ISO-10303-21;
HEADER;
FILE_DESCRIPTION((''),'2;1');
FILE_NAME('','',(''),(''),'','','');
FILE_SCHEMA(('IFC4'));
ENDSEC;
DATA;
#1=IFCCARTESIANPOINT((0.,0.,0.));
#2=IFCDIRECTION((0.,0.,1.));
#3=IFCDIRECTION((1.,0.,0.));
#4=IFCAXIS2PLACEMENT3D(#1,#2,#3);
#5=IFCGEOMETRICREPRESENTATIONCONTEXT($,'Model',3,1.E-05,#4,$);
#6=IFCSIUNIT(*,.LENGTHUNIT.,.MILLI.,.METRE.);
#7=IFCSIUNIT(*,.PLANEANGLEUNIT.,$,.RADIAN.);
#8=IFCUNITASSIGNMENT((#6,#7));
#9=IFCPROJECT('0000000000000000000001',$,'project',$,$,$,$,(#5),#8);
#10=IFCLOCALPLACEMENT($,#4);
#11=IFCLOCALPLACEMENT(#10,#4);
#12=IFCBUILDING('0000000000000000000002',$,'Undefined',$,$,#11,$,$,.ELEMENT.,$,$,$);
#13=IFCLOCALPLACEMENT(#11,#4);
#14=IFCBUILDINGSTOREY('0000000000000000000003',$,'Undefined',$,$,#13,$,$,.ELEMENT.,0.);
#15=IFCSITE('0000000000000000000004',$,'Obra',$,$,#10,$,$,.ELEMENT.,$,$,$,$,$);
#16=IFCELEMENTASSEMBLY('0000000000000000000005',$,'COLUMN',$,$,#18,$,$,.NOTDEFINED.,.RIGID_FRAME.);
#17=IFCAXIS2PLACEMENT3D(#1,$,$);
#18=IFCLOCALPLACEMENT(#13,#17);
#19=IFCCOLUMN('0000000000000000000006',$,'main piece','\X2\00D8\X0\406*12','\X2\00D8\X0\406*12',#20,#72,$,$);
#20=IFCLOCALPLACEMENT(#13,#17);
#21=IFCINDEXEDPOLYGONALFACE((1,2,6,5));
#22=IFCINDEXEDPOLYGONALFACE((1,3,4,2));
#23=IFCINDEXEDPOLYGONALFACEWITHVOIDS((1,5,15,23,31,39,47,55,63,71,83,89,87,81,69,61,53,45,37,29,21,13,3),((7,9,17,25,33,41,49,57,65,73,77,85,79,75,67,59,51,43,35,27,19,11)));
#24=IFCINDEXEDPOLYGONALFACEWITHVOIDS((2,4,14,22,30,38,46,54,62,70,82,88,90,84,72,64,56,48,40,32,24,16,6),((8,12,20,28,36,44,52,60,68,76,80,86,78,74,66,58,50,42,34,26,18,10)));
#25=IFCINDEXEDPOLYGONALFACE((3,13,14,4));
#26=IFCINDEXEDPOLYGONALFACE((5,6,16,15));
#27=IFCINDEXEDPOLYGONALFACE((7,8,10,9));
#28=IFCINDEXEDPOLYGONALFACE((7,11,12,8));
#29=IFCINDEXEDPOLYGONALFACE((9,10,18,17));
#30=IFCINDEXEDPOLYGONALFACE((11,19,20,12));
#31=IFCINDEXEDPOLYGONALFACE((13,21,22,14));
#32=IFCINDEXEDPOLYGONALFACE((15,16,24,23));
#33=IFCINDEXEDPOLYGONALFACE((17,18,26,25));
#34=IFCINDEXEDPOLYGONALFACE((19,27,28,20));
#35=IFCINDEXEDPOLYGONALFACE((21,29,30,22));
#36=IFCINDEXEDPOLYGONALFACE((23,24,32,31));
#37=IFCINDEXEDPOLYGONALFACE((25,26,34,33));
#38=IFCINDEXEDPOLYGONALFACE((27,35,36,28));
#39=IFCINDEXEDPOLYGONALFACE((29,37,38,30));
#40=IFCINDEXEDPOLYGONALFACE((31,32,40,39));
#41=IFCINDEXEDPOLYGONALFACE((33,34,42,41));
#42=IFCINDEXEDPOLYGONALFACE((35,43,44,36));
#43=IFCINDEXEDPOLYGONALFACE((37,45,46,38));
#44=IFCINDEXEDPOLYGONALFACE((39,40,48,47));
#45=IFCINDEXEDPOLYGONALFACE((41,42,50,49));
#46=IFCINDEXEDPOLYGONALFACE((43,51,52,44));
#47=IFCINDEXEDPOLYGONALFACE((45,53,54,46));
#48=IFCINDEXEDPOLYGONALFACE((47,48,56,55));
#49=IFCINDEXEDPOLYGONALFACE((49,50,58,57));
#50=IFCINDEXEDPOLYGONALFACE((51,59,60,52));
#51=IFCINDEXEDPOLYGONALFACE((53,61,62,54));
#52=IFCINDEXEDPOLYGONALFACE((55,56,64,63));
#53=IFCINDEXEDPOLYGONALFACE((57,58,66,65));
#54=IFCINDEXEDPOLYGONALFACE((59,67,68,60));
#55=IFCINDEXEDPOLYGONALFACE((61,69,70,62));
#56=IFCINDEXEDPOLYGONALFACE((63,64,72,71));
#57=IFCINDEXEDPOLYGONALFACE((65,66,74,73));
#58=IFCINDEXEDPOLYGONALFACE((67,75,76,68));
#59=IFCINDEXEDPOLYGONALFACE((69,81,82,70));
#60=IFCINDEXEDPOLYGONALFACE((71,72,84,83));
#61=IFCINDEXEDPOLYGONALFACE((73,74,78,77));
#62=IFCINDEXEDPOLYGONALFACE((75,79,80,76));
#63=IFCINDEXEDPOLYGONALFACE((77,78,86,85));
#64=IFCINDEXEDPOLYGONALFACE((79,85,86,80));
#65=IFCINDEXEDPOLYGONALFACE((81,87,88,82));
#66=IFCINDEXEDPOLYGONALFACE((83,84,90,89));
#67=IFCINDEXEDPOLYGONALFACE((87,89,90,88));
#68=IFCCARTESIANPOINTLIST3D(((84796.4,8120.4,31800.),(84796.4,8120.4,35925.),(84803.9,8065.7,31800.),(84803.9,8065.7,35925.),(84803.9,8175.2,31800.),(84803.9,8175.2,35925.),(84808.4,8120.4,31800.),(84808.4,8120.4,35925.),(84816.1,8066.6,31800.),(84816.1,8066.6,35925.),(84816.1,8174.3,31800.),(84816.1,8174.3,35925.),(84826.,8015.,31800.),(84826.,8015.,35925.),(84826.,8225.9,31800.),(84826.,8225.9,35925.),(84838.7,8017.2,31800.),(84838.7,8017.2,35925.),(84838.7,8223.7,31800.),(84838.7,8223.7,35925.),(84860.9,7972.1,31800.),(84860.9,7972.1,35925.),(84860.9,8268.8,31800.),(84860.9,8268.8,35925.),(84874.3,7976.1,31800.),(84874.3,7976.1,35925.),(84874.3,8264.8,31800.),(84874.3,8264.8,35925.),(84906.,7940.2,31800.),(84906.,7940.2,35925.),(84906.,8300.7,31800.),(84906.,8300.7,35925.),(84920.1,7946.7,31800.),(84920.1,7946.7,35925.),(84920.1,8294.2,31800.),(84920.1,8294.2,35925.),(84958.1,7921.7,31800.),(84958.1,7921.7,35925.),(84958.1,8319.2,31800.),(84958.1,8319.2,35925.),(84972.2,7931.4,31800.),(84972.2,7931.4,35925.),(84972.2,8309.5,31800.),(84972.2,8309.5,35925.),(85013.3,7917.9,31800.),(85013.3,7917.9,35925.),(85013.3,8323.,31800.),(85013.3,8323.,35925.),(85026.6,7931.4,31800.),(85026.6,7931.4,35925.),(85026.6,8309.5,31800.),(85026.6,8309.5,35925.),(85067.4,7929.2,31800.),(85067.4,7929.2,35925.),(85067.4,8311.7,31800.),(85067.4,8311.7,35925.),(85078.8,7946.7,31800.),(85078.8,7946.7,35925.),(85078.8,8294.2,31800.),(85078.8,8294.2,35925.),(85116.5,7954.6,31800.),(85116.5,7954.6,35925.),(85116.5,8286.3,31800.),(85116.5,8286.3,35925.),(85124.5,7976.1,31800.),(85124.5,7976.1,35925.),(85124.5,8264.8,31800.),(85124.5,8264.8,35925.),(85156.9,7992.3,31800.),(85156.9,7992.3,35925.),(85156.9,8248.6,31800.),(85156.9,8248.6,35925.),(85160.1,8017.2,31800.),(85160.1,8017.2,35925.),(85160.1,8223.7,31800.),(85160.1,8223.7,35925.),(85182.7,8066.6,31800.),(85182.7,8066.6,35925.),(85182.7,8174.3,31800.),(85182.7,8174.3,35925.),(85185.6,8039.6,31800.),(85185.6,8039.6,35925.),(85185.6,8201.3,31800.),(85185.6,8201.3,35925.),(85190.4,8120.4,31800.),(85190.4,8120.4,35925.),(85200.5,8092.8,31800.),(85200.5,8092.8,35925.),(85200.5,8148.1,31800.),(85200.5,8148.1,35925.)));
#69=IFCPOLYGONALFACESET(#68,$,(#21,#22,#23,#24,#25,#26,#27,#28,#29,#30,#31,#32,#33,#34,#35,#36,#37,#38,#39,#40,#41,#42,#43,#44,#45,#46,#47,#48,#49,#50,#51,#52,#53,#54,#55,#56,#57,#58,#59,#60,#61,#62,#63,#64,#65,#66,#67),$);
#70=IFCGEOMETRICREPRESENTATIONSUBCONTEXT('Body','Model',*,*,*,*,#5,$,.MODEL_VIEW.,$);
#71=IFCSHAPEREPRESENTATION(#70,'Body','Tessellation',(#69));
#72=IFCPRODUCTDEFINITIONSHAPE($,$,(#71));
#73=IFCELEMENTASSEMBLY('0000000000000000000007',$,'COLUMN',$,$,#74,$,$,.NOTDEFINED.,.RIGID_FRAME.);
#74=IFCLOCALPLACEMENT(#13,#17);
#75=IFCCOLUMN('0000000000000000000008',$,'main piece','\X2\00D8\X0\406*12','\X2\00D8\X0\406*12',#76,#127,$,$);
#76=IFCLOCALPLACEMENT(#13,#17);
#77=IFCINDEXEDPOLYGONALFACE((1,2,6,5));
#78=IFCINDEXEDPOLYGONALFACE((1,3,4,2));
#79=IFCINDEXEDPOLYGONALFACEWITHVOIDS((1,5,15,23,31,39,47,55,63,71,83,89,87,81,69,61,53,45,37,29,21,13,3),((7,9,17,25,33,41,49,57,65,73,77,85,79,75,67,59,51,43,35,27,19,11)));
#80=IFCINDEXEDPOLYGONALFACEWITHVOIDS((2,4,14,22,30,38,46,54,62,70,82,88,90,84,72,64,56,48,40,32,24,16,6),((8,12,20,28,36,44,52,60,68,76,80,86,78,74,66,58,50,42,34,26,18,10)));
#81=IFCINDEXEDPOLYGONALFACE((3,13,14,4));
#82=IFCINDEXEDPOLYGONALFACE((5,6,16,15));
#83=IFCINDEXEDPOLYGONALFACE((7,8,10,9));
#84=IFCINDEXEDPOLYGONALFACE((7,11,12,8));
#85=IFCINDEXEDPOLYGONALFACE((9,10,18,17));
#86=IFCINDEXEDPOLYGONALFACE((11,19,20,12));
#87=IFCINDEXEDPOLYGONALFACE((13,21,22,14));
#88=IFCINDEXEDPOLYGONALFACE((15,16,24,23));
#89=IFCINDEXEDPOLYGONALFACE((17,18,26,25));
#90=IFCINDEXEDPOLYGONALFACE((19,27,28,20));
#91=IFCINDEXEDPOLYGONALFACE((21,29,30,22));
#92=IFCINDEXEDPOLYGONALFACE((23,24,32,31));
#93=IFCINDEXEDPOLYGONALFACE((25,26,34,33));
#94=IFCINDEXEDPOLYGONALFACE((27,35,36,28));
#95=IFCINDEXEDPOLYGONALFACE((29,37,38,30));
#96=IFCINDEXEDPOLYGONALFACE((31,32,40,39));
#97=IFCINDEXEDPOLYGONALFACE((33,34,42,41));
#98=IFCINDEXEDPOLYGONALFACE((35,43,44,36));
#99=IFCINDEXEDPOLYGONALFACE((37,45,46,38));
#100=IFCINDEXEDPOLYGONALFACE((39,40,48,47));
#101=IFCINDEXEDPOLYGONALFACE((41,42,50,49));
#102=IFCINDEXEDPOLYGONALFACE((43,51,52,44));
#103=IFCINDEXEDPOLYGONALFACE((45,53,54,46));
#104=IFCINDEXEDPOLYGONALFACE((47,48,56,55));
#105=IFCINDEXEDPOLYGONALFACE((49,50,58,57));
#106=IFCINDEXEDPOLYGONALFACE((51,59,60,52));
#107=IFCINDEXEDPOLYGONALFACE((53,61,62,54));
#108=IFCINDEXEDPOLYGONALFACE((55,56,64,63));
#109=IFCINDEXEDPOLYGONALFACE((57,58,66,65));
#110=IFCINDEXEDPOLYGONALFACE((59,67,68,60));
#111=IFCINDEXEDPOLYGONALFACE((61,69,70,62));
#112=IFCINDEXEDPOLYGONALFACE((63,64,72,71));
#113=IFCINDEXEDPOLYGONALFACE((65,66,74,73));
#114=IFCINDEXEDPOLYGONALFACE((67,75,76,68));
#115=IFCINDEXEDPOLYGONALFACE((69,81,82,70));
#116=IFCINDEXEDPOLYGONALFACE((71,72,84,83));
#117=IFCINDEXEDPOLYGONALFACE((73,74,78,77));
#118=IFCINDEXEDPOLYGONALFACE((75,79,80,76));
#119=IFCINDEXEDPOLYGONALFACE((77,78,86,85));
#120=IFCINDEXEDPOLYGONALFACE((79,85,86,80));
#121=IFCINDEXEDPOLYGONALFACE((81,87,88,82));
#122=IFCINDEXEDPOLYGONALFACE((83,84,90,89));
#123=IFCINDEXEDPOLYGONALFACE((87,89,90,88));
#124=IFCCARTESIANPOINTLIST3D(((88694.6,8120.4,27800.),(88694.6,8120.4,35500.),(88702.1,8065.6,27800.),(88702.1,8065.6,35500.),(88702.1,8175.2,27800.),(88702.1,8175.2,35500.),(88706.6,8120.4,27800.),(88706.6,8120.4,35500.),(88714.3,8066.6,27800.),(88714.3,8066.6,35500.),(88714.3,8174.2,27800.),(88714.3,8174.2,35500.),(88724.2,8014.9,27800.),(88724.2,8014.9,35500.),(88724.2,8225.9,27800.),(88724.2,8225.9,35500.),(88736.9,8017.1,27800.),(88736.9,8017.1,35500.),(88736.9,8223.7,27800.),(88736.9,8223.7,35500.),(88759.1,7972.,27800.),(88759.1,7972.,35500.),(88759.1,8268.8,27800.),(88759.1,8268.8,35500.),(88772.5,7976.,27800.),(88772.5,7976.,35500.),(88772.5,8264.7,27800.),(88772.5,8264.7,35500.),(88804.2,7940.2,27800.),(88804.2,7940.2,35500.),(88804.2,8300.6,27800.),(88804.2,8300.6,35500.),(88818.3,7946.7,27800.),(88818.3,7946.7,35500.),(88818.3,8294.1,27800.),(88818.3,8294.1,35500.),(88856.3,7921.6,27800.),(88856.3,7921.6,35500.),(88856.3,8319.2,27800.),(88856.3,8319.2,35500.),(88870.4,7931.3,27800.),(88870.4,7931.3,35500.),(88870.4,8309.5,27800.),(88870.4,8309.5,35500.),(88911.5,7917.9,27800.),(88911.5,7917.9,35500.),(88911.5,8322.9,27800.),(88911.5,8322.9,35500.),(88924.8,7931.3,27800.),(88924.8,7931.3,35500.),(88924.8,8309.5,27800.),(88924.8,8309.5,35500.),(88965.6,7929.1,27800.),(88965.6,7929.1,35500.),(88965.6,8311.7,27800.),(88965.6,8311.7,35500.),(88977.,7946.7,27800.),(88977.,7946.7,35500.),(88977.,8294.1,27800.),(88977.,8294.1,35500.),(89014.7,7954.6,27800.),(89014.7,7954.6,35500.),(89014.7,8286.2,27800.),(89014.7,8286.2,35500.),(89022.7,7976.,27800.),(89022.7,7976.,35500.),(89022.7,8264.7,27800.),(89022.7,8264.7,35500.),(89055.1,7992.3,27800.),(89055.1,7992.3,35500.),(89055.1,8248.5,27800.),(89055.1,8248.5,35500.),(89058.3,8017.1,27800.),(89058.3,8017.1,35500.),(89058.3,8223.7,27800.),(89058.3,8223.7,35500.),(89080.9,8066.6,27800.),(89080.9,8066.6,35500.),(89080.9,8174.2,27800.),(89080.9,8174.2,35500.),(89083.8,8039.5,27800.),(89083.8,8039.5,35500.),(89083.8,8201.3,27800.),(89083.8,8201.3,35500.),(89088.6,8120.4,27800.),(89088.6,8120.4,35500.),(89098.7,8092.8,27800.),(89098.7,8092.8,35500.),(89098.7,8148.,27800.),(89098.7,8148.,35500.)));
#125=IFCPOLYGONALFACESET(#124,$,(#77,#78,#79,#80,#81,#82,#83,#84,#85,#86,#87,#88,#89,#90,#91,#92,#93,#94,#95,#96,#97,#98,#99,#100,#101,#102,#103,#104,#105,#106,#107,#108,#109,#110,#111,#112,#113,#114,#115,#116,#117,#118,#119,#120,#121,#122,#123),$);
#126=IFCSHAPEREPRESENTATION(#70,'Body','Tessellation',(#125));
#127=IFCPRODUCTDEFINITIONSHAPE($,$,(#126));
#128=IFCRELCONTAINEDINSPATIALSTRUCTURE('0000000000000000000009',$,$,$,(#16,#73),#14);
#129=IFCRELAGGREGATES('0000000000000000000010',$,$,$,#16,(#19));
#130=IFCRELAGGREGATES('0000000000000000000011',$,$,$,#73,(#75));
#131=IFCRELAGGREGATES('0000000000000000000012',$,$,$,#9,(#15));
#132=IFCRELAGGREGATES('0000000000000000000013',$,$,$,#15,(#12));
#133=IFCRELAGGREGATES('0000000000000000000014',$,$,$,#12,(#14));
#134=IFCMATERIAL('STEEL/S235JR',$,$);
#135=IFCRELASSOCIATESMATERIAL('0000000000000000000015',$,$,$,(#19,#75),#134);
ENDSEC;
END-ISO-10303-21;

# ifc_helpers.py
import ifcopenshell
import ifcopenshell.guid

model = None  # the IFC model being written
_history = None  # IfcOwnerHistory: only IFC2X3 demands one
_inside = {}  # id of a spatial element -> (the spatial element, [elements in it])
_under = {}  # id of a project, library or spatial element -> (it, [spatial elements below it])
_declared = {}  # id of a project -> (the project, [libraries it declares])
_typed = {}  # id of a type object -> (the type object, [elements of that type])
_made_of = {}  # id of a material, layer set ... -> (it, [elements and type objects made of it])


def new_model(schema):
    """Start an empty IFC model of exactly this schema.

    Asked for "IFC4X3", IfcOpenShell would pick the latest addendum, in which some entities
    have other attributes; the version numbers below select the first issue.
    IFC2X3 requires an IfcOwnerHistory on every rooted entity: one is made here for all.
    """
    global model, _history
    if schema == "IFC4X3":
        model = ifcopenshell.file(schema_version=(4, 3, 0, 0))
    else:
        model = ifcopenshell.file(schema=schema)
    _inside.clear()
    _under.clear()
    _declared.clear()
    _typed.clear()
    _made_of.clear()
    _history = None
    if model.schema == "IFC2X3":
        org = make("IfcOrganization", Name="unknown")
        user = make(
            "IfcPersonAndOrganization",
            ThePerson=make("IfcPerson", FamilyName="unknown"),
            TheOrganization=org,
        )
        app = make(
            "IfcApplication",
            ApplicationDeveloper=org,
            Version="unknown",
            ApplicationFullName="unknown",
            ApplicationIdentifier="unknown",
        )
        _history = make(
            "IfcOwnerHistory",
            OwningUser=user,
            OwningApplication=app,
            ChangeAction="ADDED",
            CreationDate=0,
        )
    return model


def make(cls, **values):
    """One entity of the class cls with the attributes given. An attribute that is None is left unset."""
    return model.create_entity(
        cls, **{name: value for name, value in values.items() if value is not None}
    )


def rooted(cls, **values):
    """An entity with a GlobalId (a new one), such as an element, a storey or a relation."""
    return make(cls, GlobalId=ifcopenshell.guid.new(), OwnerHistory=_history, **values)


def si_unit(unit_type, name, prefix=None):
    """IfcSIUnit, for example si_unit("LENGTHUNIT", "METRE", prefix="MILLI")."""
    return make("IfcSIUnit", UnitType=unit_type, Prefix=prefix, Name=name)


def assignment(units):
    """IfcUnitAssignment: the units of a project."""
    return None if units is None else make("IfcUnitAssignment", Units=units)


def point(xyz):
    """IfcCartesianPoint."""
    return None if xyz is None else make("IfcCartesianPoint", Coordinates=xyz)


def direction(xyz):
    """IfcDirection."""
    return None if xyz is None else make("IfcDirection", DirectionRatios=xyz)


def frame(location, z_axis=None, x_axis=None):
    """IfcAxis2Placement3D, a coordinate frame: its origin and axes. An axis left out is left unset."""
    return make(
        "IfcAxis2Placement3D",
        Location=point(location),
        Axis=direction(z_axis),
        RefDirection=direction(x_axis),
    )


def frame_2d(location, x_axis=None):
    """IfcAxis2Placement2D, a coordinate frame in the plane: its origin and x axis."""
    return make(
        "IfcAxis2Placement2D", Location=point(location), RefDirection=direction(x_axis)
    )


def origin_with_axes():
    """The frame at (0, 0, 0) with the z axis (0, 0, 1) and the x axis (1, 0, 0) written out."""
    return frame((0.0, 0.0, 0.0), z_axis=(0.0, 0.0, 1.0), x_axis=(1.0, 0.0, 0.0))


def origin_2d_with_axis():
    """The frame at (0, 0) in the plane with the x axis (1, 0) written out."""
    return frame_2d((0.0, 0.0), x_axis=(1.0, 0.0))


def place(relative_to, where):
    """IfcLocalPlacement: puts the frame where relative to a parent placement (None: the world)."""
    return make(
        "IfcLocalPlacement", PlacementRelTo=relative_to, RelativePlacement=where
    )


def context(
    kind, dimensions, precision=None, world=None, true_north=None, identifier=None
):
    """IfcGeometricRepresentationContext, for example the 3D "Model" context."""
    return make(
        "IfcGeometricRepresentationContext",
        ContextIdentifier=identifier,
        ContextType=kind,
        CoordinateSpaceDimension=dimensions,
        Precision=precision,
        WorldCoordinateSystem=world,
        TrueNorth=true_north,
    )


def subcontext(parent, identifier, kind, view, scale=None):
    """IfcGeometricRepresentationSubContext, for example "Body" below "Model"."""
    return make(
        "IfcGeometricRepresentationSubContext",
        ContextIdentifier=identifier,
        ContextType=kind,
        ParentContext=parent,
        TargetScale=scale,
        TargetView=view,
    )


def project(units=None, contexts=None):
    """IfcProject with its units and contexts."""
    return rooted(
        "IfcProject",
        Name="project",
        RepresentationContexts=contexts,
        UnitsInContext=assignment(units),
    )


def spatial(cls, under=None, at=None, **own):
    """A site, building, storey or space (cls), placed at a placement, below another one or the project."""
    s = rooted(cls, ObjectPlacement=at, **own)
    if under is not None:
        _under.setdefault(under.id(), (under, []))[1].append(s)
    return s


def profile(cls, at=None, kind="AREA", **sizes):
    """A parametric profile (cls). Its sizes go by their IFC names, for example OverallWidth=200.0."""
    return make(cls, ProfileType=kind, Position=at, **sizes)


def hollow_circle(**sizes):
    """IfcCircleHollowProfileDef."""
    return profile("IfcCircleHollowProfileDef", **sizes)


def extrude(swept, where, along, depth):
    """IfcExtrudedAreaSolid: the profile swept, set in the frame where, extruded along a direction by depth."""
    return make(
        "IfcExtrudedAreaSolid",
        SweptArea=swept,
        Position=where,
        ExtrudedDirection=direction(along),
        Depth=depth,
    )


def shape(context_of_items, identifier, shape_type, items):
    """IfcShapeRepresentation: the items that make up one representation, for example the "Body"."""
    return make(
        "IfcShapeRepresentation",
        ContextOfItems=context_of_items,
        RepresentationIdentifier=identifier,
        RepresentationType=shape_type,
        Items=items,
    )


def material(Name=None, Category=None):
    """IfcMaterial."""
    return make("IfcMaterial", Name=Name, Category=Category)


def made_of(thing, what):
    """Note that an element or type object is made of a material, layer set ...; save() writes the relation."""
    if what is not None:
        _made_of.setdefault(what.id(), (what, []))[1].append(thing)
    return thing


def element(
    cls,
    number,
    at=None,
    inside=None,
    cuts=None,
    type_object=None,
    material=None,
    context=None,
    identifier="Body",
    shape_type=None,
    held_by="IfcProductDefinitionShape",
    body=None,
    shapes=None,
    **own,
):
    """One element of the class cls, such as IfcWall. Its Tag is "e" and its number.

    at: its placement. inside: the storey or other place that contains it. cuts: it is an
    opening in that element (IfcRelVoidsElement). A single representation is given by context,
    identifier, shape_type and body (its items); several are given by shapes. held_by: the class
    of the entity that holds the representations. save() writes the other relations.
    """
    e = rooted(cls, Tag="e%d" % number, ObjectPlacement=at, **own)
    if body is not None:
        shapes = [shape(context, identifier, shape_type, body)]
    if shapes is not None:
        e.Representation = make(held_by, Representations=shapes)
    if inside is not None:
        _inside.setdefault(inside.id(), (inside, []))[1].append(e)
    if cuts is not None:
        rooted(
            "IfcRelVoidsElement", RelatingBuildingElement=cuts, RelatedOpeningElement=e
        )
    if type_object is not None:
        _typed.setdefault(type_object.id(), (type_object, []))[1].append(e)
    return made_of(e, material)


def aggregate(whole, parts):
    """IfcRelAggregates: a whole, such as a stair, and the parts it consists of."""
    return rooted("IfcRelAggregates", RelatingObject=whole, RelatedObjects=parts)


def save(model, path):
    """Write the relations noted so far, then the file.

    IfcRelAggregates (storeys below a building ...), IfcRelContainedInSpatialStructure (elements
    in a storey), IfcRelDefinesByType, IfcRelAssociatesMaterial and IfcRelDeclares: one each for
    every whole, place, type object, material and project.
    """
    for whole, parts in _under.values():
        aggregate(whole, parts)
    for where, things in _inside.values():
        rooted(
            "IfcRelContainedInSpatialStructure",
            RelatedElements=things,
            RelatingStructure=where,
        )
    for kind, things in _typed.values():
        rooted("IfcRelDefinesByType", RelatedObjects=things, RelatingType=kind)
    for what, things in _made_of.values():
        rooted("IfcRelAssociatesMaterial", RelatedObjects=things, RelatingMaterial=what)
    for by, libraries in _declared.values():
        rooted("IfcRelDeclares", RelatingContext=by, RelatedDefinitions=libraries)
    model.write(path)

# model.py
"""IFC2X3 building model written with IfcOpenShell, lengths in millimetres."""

from ifc_helpers import new_model, si_unit, frame, origin_with_axes, origin_2d_with_axis, place, context, subcontext, project, spatial, hollow_circle, extrude, material, element, aggregate, save


model = new_model("IFC2X3")

# Units and contexts
model_context = context("Model", 3, precision=1e-05, world=origin_with_axes())
body_context = subcontext(model_context, "Body", "Model", "MODEL_VIEW")
ifc_project = project(units=[si_unit("LENGTHUNIT", "METRE", prefix="MILLI"), si_unit("PLANEANGLEUNIT", "RADIAN")], contexts=[model_context])

# Site, building, storey
site_placement = place(None, origin_with_axes())
site = spatial("IfcSite", under=ifc_project, at=site_placement, Name="Obra", CompositionType="ELEMENT")
building_placement = place(site_placement, origin_with_axes())
building = spatial("IfcBuilding", under=site, at=building_placement, Name="Undefined", CompositionType="ELEMENT")
storey_placement = place(building_placement, origin_with_axes())
storey = spatial("IfcBuildingStorey", under=building, at=storey_placement, Name="Undefined", CompositionType="ELEMENT", Elevation=0.0)

# Element assemblies, columns
assembly_1_placement = place(storey_placement, origin_with_axes())
assembly_1 = element("IfcElementAssembly", 1, at=assembly_1_placement, inside=storey, Name="COLUMN", AssemblyPlace="NOTDEFINED", PredefinedType="RIGID_FRAME")
ifc_material_1 = material(Name="STEEL/S235JR")
column_1_placement = place(assembly_1_placement, frame((84999.4, 8120.4, 31800.0), z_axis=(0.0, 0.0, 1.0), x_axis=(0.0, 1.0, 0.0)))
column_1 = element("IfcColumn", 2, at=column_1_placement, material=ifc_material_1, Name="main piece", Description="Ø406*12", ObjectType="Ø406*12", context=body_context, shape_type="SweptSolid", body=[
    extrude(hollow_circle(Radius=203.0, WallThickness=12.0, at=origin_2d_with_axis()), frame((0.0, 0.0, 4125.0), z_axis=(0.0, 0.0, -1.0), x_axis=(0.0, 1.0, 0.0)), (0.0, 0.0, 1.0), 4125.0),
])
assembly_2_placement = place(storey_placement, origin_with_axes())
assembly_2 = element("IfcElementAssembly", 3, at=assembly_2_placement, inside=storey, Name="COLUMN", AssemblyPlace="NOTDEFINED", PredefinedType="RIGID_FRAME")
column_2_placement = place(assembly_2_placement, frame((88897.6, 8120.4, 27800.0), z_axis=(0.0, 0.0, 1.0), x_axis=(0.0, 1.0, 0.0)))
column_2 = element("IfcColumn", 4, at=column_2_placement, material=ifc_material_1, Name="main piece", Description="Ø406*12", ObjectType="Ø406*12", context=body_context, shape_type="SweptSolid", body=[
    extrude(hollow_circle(Radius=203.0, WallThickness=12.0, at=origin_2d_with_axis()), frame((0.0, 0.0, 7700.0), z_axis=(0.0, 0.0, -1.0), x_axis=(0.0, 1.0, 0.0)), (0.0, 0.0, 1.0), 7700.0),
])

aggregate(assembly_1, [column_1])
aggregate(assembly_2, [column_2])

save(model, "model.ifc")
